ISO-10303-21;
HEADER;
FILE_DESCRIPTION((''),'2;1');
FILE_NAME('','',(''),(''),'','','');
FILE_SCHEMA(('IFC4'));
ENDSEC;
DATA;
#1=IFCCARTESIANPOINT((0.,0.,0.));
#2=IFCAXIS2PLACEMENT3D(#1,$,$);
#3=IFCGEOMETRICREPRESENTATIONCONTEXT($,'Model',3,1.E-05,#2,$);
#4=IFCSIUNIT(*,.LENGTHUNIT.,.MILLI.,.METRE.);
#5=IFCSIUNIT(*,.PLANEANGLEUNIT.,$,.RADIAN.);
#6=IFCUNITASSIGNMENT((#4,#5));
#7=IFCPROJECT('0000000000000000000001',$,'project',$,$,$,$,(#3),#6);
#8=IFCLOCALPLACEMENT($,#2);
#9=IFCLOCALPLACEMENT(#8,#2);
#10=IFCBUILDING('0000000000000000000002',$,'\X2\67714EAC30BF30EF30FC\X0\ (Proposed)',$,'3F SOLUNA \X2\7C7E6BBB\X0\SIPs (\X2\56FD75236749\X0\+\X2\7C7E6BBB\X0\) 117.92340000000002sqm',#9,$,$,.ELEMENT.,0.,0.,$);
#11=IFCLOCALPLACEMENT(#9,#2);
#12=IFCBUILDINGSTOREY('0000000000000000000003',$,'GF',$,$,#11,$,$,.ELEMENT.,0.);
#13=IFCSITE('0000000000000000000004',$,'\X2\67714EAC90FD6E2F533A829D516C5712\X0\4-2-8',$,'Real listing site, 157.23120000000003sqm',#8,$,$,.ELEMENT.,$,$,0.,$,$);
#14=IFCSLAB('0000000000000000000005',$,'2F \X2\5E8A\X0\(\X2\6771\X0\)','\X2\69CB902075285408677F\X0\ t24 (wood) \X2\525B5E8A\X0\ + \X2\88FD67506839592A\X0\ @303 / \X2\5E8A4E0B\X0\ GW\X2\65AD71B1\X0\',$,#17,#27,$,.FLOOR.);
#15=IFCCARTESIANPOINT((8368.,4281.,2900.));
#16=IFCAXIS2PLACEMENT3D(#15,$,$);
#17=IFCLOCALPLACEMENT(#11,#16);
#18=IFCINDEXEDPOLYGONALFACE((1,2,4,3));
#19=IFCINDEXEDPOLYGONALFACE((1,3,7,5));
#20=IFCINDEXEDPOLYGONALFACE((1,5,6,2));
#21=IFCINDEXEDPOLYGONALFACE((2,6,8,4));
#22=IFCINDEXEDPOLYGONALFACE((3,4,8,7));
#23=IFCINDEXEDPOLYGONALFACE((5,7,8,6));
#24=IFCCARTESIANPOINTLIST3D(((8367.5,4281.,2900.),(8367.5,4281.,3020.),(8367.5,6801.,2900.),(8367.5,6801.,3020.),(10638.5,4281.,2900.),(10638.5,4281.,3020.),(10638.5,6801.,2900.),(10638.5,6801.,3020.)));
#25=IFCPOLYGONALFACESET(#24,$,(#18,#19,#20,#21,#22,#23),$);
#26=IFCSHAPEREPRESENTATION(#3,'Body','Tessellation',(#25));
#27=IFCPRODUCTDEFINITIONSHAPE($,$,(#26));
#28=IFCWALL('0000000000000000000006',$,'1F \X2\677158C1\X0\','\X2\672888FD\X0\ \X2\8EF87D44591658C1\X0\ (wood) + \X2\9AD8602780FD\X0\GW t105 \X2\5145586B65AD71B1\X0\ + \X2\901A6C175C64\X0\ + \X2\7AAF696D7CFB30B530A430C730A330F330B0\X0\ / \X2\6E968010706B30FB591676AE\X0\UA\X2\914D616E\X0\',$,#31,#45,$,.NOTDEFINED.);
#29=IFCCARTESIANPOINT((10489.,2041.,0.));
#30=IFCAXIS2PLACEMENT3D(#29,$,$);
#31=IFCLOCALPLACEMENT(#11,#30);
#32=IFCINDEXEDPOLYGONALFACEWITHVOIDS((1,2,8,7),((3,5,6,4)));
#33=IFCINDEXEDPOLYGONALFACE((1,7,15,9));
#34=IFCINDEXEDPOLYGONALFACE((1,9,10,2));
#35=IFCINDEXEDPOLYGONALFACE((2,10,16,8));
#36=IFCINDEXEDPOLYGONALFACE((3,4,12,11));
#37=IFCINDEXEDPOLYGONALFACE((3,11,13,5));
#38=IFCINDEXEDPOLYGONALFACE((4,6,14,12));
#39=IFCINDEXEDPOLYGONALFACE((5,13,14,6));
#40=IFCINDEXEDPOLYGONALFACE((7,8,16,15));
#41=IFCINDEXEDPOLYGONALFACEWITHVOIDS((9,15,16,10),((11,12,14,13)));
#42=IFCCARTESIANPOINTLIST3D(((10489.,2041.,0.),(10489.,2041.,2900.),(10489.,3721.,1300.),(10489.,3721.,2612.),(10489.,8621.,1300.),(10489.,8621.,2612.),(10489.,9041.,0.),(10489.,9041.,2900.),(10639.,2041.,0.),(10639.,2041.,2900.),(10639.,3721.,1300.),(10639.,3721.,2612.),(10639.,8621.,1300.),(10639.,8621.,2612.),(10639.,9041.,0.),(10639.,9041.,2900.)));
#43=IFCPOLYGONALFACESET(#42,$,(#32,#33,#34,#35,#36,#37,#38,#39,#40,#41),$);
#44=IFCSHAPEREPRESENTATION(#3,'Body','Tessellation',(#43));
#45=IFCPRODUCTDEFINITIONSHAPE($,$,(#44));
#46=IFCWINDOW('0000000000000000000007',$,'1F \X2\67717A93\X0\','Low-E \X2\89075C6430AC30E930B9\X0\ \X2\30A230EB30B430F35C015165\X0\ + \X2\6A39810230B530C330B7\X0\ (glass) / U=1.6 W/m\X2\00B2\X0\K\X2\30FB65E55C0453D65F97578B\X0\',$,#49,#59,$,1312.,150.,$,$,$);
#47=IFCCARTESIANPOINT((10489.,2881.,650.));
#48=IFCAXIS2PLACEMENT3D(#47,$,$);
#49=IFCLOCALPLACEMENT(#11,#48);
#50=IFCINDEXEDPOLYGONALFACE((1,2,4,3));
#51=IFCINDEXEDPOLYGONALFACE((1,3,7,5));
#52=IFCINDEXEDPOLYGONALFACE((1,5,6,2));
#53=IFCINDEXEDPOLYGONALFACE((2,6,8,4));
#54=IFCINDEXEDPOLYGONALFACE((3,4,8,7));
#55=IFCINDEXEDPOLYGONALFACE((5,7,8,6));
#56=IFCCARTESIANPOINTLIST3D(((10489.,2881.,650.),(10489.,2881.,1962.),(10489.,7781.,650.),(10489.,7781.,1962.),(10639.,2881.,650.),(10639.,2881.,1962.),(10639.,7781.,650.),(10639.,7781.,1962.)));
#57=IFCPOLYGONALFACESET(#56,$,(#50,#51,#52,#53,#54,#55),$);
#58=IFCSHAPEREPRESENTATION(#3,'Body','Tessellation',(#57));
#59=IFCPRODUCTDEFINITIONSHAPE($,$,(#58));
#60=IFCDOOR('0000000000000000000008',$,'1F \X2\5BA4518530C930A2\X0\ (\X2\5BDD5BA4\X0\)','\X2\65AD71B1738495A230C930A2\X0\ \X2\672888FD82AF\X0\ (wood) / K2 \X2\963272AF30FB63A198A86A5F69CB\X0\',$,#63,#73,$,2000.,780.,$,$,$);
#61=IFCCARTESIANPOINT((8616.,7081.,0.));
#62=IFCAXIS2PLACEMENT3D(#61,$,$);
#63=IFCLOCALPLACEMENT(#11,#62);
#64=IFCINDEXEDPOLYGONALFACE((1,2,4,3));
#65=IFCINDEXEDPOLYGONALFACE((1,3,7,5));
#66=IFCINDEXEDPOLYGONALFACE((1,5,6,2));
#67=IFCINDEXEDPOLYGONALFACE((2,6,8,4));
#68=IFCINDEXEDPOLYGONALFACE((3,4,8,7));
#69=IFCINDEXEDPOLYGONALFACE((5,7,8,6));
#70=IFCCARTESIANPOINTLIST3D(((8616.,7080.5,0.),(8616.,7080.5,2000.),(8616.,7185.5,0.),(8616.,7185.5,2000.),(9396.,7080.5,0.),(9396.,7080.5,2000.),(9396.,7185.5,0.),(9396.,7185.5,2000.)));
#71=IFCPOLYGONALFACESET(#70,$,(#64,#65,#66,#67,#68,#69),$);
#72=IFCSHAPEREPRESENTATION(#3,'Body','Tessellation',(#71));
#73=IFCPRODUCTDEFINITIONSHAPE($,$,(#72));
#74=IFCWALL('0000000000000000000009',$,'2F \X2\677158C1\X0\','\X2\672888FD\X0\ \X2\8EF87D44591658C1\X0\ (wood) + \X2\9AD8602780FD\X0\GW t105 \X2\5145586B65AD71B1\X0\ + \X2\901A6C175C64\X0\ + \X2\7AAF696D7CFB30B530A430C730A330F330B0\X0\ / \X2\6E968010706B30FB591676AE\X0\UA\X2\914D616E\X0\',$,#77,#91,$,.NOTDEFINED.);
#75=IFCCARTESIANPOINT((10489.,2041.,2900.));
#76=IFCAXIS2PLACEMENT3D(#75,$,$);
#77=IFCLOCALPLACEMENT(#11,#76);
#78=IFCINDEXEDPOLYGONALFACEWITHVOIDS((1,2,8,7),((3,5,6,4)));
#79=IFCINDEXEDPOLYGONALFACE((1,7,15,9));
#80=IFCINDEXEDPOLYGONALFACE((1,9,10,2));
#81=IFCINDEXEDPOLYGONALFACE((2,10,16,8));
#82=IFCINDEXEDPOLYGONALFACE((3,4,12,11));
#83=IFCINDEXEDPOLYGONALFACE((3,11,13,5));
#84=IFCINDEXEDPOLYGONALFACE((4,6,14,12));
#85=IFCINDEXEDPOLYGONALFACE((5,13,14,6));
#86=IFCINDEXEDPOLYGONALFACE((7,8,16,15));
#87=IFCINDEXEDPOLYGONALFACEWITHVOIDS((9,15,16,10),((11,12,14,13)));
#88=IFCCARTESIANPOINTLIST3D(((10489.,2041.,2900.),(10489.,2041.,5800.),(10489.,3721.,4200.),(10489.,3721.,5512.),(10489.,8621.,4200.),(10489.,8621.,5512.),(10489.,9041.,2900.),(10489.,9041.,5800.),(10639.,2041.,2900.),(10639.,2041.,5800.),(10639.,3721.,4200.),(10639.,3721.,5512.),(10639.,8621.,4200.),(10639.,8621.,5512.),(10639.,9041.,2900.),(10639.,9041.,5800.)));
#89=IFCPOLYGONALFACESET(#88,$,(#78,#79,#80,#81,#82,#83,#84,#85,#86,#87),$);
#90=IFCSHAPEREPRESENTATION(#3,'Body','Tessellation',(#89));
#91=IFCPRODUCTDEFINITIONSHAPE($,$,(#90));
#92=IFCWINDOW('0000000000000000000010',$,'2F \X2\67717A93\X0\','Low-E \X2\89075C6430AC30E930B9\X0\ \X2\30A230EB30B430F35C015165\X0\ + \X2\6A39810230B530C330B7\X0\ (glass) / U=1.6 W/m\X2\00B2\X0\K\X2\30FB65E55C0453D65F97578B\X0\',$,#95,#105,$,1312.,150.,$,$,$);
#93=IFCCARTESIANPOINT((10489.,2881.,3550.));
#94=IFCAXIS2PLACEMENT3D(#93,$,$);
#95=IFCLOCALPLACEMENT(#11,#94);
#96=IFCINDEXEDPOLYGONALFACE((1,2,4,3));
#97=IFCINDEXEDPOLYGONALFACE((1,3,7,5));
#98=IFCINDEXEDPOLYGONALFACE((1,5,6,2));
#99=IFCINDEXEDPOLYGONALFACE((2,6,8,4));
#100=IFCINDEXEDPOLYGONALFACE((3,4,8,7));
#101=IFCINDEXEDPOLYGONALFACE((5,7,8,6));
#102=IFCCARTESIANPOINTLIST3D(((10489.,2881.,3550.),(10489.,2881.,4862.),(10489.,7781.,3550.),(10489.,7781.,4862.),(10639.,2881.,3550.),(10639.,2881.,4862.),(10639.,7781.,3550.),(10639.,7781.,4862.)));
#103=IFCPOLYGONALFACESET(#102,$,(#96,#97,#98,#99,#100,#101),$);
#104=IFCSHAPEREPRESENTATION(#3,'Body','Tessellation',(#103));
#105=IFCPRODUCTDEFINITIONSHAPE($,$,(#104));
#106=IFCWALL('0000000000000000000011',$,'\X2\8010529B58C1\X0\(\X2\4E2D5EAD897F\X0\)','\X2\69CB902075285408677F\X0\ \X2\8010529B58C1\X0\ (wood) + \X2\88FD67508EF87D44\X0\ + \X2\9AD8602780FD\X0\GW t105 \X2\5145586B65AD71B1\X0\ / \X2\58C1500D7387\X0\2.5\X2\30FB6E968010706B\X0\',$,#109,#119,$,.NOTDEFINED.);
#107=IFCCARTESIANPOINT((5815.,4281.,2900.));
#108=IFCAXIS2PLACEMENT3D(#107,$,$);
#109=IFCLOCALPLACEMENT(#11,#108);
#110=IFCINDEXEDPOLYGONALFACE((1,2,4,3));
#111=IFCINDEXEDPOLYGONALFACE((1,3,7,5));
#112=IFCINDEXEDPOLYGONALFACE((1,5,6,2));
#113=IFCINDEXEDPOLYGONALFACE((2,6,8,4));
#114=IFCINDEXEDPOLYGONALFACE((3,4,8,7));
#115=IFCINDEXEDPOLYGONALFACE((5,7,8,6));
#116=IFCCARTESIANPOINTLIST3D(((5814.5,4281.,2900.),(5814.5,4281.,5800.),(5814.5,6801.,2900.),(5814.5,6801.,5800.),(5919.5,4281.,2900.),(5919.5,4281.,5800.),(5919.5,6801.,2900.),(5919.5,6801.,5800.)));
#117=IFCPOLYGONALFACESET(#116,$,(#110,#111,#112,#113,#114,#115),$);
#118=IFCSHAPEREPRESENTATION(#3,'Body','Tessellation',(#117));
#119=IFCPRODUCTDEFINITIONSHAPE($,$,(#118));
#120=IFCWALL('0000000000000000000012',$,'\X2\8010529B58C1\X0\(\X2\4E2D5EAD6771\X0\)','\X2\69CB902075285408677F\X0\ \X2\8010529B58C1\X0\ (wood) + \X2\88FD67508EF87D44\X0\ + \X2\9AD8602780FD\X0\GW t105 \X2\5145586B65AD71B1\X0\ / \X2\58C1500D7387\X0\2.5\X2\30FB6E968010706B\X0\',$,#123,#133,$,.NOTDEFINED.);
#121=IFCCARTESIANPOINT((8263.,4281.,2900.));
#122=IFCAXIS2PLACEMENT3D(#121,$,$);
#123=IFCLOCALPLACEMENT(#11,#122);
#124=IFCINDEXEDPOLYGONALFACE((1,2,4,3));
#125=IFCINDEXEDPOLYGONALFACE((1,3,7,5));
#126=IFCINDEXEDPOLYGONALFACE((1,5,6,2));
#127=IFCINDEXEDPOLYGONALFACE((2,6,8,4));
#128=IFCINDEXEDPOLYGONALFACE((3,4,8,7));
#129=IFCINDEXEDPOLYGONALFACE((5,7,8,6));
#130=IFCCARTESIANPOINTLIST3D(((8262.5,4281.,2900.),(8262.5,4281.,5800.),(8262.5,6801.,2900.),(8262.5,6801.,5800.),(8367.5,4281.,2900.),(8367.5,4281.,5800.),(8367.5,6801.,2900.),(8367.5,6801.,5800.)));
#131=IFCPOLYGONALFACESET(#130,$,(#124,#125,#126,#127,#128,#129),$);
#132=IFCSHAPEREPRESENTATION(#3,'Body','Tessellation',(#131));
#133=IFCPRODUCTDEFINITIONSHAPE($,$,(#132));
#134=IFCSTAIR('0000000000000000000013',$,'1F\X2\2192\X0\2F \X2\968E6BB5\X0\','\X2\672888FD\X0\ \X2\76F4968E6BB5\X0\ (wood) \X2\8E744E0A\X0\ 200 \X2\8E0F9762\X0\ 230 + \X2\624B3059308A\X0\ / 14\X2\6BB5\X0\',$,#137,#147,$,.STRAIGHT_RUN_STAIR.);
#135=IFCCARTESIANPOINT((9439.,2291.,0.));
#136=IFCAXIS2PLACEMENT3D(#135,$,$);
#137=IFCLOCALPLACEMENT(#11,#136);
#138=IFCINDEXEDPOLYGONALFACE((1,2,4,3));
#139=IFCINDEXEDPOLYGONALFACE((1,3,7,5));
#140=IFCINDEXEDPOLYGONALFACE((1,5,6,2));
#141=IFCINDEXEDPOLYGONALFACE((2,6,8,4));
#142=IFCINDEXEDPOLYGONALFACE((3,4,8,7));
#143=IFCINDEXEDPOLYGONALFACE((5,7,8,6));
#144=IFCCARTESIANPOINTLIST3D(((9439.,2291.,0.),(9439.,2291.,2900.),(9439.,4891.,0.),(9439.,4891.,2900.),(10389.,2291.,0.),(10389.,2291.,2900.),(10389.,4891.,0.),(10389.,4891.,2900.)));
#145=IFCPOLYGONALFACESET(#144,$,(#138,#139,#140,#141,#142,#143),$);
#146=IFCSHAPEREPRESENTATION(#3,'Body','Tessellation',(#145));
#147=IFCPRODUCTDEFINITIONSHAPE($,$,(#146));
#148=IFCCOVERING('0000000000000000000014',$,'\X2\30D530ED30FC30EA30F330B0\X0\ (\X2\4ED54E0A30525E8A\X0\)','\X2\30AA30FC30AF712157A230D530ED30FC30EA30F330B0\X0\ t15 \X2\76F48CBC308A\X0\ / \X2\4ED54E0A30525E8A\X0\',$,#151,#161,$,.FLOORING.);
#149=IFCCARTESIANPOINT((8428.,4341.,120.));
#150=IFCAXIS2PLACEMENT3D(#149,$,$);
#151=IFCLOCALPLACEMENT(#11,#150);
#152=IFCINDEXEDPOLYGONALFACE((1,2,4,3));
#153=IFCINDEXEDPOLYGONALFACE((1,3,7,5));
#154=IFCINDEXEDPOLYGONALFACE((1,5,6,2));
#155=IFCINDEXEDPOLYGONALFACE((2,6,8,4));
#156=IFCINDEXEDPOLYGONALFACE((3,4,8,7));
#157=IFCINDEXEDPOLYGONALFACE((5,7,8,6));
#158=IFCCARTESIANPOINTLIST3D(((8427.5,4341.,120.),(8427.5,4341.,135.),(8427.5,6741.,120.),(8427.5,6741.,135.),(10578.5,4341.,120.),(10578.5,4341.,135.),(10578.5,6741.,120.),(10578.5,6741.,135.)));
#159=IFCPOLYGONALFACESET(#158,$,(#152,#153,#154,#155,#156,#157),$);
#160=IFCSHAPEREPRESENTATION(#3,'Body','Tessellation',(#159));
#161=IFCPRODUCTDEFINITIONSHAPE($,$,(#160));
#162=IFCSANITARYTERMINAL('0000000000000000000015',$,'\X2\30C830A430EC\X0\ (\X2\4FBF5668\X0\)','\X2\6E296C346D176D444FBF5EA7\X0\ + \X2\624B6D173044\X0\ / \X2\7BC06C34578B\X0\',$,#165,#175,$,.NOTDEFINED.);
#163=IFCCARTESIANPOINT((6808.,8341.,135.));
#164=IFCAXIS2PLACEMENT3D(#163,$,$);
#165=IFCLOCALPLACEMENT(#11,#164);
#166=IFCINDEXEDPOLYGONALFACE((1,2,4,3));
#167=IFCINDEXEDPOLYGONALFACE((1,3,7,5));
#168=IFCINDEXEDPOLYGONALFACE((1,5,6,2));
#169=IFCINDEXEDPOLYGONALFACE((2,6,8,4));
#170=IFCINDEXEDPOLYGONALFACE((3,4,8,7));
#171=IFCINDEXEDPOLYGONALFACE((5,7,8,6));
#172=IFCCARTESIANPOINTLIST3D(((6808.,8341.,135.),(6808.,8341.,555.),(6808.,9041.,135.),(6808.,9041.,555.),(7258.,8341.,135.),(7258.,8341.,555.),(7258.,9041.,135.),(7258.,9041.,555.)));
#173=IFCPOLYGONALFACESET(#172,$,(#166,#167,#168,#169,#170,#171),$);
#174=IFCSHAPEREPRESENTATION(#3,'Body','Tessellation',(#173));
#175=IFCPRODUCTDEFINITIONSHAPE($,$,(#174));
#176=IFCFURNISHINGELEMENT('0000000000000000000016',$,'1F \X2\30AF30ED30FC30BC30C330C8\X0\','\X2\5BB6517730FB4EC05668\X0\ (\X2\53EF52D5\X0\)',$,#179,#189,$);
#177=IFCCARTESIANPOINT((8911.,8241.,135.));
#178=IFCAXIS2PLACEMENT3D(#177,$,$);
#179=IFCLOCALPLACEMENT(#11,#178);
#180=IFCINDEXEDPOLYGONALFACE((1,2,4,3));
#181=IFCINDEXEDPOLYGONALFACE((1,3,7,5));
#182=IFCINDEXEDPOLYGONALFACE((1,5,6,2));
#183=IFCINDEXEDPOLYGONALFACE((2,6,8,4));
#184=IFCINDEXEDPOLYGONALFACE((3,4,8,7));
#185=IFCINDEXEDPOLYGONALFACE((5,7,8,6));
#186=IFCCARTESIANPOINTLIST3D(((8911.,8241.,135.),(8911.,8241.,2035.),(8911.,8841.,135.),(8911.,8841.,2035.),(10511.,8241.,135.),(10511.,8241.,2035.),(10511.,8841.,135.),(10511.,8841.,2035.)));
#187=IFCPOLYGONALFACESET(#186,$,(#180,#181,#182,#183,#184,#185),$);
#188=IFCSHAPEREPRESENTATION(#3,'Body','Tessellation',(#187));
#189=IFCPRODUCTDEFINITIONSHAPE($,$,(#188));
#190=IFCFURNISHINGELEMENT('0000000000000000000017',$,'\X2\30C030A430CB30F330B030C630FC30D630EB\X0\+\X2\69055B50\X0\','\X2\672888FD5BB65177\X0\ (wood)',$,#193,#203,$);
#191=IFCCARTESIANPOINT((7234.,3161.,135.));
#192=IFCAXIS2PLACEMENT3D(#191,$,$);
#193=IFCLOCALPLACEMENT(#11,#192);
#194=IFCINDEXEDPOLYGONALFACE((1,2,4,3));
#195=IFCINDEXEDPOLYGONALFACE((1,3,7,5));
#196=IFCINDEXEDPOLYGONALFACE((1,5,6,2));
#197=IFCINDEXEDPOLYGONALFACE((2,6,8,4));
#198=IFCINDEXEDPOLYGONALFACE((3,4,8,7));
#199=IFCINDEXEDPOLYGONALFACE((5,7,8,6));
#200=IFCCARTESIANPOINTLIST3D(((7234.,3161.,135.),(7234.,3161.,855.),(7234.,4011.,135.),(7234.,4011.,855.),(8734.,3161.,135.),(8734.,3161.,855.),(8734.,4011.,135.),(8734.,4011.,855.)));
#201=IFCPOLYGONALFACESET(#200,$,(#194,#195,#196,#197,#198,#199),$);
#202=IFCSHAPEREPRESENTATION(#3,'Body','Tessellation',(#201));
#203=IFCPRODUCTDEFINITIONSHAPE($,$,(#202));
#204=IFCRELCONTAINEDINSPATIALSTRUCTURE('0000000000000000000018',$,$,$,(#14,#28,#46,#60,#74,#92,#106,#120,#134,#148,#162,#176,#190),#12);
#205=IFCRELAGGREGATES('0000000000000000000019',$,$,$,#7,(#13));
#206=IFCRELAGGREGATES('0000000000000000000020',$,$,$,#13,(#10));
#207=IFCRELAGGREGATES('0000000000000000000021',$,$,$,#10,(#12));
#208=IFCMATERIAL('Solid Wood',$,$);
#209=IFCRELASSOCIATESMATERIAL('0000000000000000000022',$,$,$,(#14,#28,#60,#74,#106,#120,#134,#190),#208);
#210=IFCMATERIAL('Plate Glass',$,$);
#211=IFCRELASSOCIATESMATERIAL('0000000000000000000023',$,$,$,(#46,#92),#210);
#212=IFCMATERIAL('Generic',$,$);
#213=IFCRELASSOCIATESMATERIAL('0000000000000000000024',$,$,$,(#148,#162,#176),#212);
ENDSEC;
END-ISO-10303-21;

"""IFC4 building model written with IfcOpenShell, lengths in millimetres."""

from ifc_helpers import new_model, si_unit, frame, frame_2d, origin, place, context, project, spatial, rectangle, extrude, material, element, fill, save


model = new_model("IFC4")

# Units and contexts
model_context = context("Model", 3, precision=1e-05, world=origin())
ifc_project = project(units=[si_unit("LENGTHUNIT", "METRE", prefix="MILLI"), si_unit("PLANEANGLEUNIT", "RADIAN")], contexts=[model_context])

# Site, building, storey
site_placement = place(None, origin())
site = spatial("IfcSite", under=ifc_project, at=site_placement, Name="東京都港区芝公園4-2-8", ObjectType="Real listing site, 157.23120000000003sqm", CompositionType="ELEMENT", RefElevation=0.0)
building_placement = place(site_placement, origin())
building = spatial("IfcBuilding", under=site, at=building_placement, Name="東京タワー (Proposed)", ObjectType="3F SOLUNA 籾殻SIPs (国産杉+籾殻) 117.92340000000002sqm", CompositionType="ELEMENT", ElevationOfRefHeight=0.0, ElevationOfTerrain=0.0)
storey_placement = place(building_placement, origin())
storey = spatial("IfcBuildingStorey", under=building, at=storey_placement, Name="GF", CompositionType="ELEMENT", Elevation=0.0)

# Slab
ifc_material_1 = material(Name="Solid Wood")
slab_1_placement = place(storey_placement, frame((8368.0, 4281.0, 2900.0)))
element("IfcSlab", 1, at=slab_1_placement, inside=storey, material=ifc_material_1, Name="2F 床(東)", Description="構造用合板 t24 (wood) 剛床 + 製材根太 @303 / 床下 GW断熱", PredefinedType="FLOOR", context=model_context, shape_type="SweptSolid", body=[
    extrude(rectangle(XDim=2271.0, YDim=2520.0, at=frame_2d((1135.0, 1260.0))), frame((8368.0, 4281.0, 2900.0)), (0.0, 0.0, 1.0), 120.0),
])

# Wall, opening, window
wall_1_placement = place(storey_placement, frame((10489.0, 2041.0, 0.0)))
wall_1 = element("IfcWall", 2, at=wall_1_placement, inside=storey, material=ifc_material_1, Name="1F 東壁", Description="木製 軸組外壁 (wood) + 高性能GW t105 充填断熱 + 通気層 + 窯業系サイディング / 準耐火・外皮UA配慮", PredefinedType="NOTDEFINED", context=model_context, shape_type="SweptSolid", body=[
    extrude(rectangle(XDim=150.0, YDim=7000.0, at=frame_2d((75.0, 3500.0))), frame((10489.0, 2041.0, 0.0)), (0.0, 0.0, 1.0), 2900.0),
])
opening_1_placement = place(storey_placement, frame((10489.0, 2881.0, 650.0)))
opening_1 = element("IfcOpeningElement", 3, at=opening_1_placement, cuts=wall_1, PredefinedType="NOTDEFINED", context=model_context, shape_type="SweptSolid", body=[
    extrude(rectangle(XDim=150.0, YDim=4900.0, at=frame_2d((75.0, 2450.0))), frame((10489.0, 2881.0, 650.0)), (0.0, 0.0, 1.0), 1312.0),
])
ifc_material_2 = material(Name="Plate Glass")
window_1_placement = place(storey_placement, frame((10489.0, 2881.0, 650.0)))
window_1 = element("IfcWindow", 4, at=window_1_placement, inside=storey, material=ifc_material_2, Name="1F 東窓", Description="Low-E 複層ガラス アルゴン封入 + 樹脂サッシ (glass) / U=1.6 W/m²K・日射取得型", OverallHeight=1312.0, OverallWidth=150.0, context=model_context, shape_type="SweptSolid", body=[
    extrude(rectangle(XDim=150.0, YDim=4900.0, at=frame_2d((75.0, 2450.0))), frame((10489.0, 2881.0, 650.0)), (0.0, 0.0, 1.0), 1312.0),
])
fill(opening_1, window_1)

# Door
door_placement = place(storey_placement, frame((8616.0, 7081.0, 0.0)))
element("IfcDoor", 5, at=door_placement, inside=storey, material=ifc_material_1, Name="1F 室内ドア (寝室)", Description="断熱玄関ドア 木製芯 (wood) / K2 防犯・採風機構", OverallHeight=2000.0, OverallWidth=780.0, context=model_context, shape_type="SweptSolid", body=[
    extrude(rectangle(XDim=780.0, YDim=105.0, at=frame_2d((390.0, 52.0))), frame((8616.0, 7081.0, 0.0)), (0.0, 0.0, 1.0), 2000.0),
])

# Wall, opening, window
wall_2_placement = place(storey_placement, frame((10489.0, 2041.0, 2900.0)))
wall_2 = element("IfcWall", 6, at=wall_2_placement, inside=storey, material=ifc_material_1, Name="2F 東壁", Description="木製 軸組外壁 (wood) + 高性能GW t105 充填断熱 + 通気層 + 窯業系サイディング / 準耐火・外皮UA配慮", PredefinedType="NOTDEFINED", context=model_context, shape_type="SweptSolid", body=[
    extrude(rectangle(XDim=150.0, YDim=7000.0, at=frame_2d((75.0, 3500.0))), frame((10489.0, 2041.0, 2900.0)), (0.0, 0.0, 1.0), 2900.0),
])
opening_2_placement = place(storey_placement, frame((10489.0, 2881.0, 3550.0)))
opening_2 = element("IfcOpeningElement", 7, at=opening_2_placement, cuts=wall_2, PredefinedType="NOTDEFINED", context=model_context, shape_type="SweptSolid", body=[
    extrude(rectangle(XDim=150.0, YDim=4900.0, at=frame_2d((75.0, 2450.0))), frame((10489.0, 2881.0, 3550.0)), (0.0, 0.0, 1.0), 1312.0),
])
window_2_placement = place(storey_placement, frame((10489.0, 2881.0, 3550.0)))
window_2 = element("IfcWindow", 8, at=window_2_placement, inside=storey, material=ifc_material_2, Name="2F 東窓", Description="Low-E 複層ガラス アルゴン封入 + 樹脂サッシ (glass) / U=1.6 W/m²K・日射取得型", OverallHeight=1312.0, OverallWidth=150.0, context=model_context, shape_type="SweptSolid", body=[
    extrude(rectangle(XDim=150.0, YDim=4900.0, at=frame_2d((75.0, 2450.0))), frame((10489.0, 2881.0, 3550.0)), (0.0, 0.0, 1.0), 1312.0),
])
fill(opening_2, window_2)

# Walls
wall_3_placement = place(storey_placement, frame((5815.0, 4281.0, 2900.0)))
element("IfcWall", 9, at=wall_3_placement, inside=storey, material=ifc_material_1, Name="耐力壁(中庭西)", Description="構造用合板 耐力壁 (wood) + 製材軸組 + 高性能GW t105 充填断熱 / 壁倍率2.5・準耐火", PredefinedType="NOTDEFINED", context=model_context, shape_type="SweptSolid", body=[
    extrude(rectangle(XDim=105.0, YDim=2520.0, at=frame_2d((52.0, 1260.0))), frame((5815.0, 4281.0, 2900.0)), (0.0, 0.0, 1.0), 2900.0),
])
wall_4_placement = place(storey_placement, frame((8263.0, 4281.0, 2900.0)))
element("IfcWall", 10, at=wall_4_placement, inside=storey, material=ifc_material_1, Name="耐力壁(中庭東)", Description="構造用合板 耐力壁 (wood) + 製材軸組 + 高性能GW t105 充填断熱 / 壁倍率2.5・準耐火", PredefinedType="NOTDEFINED", context=model_context, shape_type="SweptSolid", body=[
    extrude(rectangle(XDim=105.0, YDim=2520.0, at=frame_2d((52.0, 1260.0))), frame((8263.0, 4281.0, 2900.0)), (0.0, 0.0, 1.0), 2900.0),
])

# Stair
stair_placement = place(storey_placement, frame((9439.0, 2291.0, 0.0)))
element("IfcStair", 11, at=stair_placement, inside=storey, material=ifc_material_1, Name="1F→2F 階段", Description="木製 直階段 (wood) 蹴上 200 踏面 230 + 手すり / 14段", PredefinedType="STRAIGHT_RUN_STAIR", context=model_context, shape_type="SweptSolid", body=[
    extrude(rectangle(XDim=950.0, YDim=2600.0, at=frame_2d((475.0, 1300.0))), frame((9439.0, 2291.0, 0.0)), (0.0, 0.0, 1.0), 2900.0),
])

# Covering
ifc_material_3 = material(Name="Generic")
covering_placement = place(storey_placement, frame((8428.0, 4341.0, 120.0)))
element("IfcCovering", 12, at=covering_placement, inside=storey, material=ifc_material_3, Name="フローリング (仕上げ床)", Description="オーク無垢フローリング t15 直貼り / 仕上げ床", PredefinedType="FLOORING", context=model_context, shape_type="SweptSolid", body=[
    extrude(rectangle(XDim=2151.0, YDim=2400.0, at=frame_2d((1075.0, 1200.0))), frame((8428.0, 4341.0, 120.0)), (0.0, 0.0, 1.0), 15.0),
])

# Sanitary terminal
sanitary_terminal_placement = place(storey_placement, frame((6808.0, 8341.0, 135.0)))
element("IfcSanitaryTerminal", 13, at=sanitary_terminal_placement, inside=storey, material=ifc_material_3, Name="トイレ (便器)", Description="温水洗浄便座 + 手洗い / 節水型", PredefinedType="NOTDEFINED", context=model_context, shape_type="SweptSolid", body=[
    extrude(rectangle(XDim=450.0, YDim=700.0, at=frame_2d((225.0, 350.0))), frame((6808.0, 8341.0, 135.0)), (0.0, 0.0, 1.0), 420.0),
])

# Furnishing elements
furnishing_1_placement = place(storey_placement, frame((8911.0, 8241.0, 135.0)))
element("IfcFurnishingElement", 14, at=furnishing_1_placement, inside=storey, material=ifc_material_3, Name="1F クローゼット", Description="家具・什器 (可動)", context=model_context, shape_type="SweptSolid", body=[
    extrude(rectangle(XDim=1600.0, YDim=600.0, at=frame_2d((800.0, 300.0))), frame((8911.0, 8241.0, 135.0)), (0.0, 0.0, 1.0), 1900.0),
])
furnishing_2_placement = place(storey_placement, frame((7234.0, 3161.0, 135.0)))
element("IfcFurnishingElement", 15, at=furnishing_2_placement, inside=storey, material=ifc_material_1, Name="ダイニングテーブル+椅子", Description="木製家具 (wood)", context=model_context, shape_type="SweptSolid", body=[
    extrude(rectangle(XDim=1500.0, YDim=850.0, at=frame_2d((750.0, 425.0))), frame((7234.0, 3161.0, 135.0)), (0.0, 0.0, 1.0), 720.0),
])

save(model, "model.ifc")
